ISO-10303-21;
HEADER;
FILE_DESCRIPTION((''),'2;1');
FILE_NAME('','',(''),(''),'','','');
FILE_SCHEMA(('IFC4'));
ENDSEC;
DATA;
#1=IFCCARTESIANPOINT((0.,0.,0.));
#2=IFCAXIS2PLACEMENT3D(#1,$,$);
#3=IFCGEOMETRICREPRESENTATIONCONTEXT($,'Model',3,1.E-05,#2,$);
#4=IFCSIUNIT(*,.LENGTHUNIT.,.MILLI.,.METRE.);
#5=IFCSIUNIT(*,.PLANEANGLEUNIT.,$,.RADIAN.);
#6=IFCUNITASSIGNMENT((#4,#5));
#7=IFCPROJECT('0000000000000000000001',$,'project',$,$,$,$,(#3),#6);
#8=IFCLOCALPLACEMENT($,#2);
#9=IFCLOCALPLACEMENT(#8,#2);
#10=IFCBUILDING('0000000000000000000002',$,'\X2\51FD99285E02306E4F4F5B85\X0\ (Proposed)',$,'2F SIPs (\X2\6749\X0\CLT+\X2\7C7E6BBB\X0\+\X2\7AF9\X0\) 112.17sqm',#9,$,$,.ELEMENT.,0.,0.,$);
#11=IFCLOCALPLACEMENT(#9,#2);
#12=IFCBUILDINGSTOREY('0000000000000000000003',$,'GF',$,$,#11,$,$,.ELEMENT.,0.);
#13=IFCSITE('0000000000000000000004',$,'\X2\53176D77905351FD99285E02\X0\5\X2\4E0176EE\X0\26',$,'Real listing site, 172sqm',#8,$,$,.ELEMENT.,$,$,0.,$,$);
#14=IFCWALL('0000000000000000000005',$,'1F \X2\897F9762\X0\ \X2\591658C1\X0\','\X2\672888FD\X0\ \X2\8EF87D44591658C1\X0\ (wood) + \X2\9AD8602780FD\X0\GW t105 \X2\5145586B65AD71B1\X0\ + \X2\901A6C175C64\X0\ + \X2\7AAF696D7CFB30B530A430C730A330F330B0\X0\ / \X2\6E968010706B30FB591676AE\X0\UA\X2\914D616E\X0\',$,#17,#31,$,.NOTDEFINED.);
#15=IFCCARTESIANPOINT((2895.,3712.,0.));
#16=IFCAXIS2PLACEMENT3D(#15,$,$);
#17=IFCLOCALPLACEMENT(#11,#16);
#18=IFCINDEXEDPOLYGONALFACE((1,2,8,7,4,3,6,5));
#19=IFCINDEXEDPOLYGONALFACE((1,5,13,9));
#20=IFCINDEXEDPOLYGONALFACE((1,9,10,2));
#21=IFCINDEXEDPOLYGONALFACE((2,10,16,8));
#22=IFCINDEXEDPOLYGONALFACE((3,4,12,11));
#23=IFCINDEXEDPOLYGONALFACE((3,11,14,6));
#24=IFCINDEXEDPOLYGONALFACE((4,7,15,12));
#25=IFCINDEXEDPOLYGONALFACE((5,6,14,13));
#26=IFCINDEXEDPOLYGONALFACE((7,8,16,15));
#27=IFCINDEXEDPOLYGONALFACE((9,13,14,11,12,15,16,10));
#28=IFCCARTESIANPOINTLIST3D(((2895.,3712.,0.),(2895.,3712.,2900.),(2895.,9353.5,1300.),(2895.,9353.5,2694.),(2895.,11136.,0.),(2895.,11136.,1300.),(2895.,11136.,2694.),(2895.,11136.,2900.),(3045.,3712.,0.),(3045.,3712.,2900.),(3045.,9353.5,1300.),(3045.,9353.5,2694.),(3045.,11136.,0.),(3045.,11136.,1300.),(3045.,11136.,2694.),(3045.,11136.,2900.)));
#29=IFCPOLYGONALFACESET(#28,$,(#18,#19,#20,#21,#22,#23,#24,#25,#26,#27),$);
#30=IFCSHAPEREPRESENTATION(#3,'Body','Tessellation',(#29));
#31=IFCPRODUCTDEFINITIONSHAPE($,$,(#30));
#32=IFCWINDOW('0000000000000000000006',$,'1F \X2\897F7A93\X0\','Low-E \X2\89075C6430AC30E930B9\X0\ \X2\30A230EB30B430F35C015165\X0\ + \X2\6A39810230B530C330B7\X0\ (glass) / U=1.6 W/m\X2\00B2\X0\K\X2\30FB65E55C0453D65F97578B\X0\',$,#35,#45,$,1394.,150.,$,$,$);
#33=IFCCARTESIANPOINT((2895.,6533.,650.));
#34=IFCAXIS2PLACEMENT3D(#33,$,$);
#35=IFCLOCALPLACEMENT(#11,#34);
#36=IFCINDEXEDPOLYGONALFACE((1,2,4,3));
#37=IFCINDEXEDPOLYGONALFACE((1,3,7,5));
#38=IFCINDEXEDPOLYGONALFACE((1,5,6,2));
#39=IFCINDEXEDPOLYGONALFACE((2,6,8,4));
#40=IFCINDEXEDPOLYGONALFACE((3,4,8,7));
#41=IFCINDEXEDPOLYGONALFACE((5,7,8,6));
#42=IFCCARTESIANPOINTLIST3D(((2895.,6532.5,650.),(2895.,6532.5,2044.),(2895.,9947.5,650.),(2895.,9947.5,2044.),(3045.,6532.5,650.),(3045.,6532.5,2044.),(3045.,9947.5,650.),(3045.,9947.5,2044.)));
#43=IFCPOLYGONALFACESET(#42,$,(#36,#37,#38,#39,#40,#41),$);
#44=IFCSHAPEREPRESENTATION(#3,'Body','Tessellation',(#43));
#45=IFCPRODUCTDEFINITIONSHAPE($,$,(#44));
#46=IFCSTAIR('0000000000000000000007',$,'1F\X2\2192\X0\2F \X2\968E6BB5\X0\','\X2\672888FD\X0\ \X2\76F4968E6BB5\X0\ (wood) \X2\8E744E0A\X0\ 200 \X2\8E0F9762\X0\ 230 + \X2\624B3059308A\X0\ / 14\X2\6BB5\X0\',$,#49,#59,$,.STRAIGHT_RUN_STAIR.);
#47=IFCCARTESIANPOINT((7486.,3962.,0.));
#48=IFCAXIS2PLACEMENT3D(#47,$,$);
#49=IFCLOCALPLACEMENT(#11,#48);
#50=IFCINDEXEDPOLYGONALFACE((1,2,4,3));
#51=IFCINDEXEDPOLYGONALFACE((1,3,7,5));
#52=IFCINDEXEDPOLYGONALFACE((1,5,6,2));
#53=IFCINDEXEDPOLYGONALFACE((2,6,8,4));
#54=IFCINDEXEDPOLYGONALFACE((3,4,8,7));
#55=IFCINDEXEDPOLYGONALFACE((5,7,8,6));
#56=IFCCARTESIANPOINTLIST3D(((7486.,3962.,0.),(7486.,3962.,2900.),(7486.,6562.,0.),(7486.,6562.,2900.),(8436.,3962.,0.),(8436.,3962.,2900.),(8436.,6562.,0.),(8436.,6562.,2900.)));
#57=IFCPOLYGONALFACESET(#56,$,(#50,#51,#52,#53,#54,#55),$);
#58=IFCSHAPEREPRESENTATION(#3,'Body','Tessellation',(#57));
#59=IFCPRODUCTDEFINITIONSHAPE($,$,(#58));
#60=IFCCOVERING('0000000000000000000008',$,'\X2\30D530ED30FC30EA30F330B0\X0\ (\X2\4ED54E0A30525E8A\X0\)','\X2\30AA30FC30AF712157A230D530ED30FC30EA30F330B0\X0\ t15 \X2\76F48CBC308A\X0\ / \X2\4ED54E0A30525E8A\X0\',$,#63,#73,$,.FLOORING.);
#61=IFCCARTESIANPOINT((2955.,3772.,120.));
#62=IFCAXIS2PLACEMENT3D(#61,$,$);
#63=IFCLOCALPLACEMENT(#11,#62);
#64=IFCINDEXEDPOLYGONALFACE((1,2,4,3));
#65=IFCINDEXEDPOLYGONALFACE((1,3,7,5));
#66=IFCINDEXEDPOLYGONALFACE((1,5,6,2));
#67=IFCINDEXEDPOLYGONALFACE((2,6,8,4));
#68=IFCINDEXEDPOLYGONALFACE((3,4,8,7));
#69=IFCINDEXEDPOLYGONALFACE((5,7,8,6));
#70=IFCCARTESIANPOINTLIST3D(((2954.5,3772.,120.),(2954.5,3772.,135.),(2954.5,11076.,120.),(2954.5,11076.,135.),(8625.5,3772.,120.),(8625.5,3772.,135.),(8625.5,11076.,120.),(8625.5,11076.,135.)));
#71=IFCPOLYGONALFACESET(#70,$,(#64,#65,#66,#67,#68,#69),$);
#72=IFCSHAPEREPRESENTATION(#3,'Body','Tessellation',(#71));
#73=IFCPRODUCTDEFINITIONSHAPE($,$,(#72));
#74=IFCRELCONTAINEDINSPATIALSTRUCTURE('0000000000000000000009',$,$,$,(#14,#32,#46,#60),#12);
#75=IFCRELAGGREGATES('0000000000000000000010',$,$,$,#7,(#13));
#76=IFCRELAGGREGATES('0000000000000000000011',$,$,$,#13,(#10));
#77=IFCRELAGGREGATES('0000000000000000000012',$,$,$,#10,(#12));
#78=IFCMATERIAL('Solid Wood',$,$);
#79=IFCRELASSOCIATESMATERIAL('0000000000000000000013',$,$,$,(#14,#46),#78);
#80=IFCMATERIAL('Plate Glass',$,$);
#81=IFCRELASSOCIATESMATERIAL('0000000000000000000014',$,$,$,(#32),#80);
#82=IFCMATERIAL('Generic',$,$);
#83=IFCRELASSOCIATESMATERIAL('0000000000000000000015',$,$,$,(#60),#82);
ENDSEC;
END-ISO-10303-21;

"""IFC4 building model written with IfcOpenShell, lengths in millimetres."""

from ifc_helpers import new_model, si_unit, frame, frame_2d, origin, place, context, project, spatial, rectangle, extrude, material, element, fill, save


model = new_model("IFC4")

# Units and contexts
model_context = context("Model", 3, precision=1e-05, world=origin())
ifc_project = project(units=[si_unit("LENGTHUNIT", "METRE", prefix="MILLI"), si_unit("PLANEANGLEUNIT", "RADIAN")], contexts=[model_context])

# Site, building, storey
site_placement = place(None, origin())
site = spatial("IfcSite", under=ifc_project, at=site_placement, Name="北海道函館市5丁目26", ObjectType="Real listing site, 172sqm", CompositionType="ELEMENT", RefElevation=0.0)
building_placement = place(site_placement, origin())
building = spatial("IfcBuilding", under=site, at=building_placement, Name="函館市の住宅 (Proposed)", ObjectType="2F SIPs (杉CLT+籾殻+竹) 112.17sqm", CompositionType="ELEMENT", ElevationOfRefHeight=0.0, ElevationOfTerrain=0.0)
storey_placement = place(building_placement, origin())
storey = spatial("IfcBuildingStorey", under=building, at=storey_placement, Name="GF", CompositionType="ELEMENT", Elevation=0.0)

# Shared definitions
ifc_material_1 = material(Name="Solid Wood")
ifc_material_2 = material(Name="Generic")

# Shared definitions
ifc_material_3 = material(Name="Plate Glass")

# Wall, opening, window
wall_1_placement = place(storey_placement, frame((2895.0, 3712.0, 0.0)))
wall_1 = element("IfcWall", 1, at=wall_1_placement, inside=storey, material=ifc_material_1, Name="1F 西面 外壁", Description="木製 軸組外壁 (wood) + 高性能GW t105 充填断熱 + 通気層 + 窯業系サイディング / 準耐火・外皮UA配慮", PredefinedType="NOTDEFINED", context=model_context, shape_type="SweptSolid", body=[
    extrude(rectangle(XDim=150.0, YDim=7424.0, at=frame_2d((75.0, 3712.0))), frame((2895.0, 3712.0, 0.0)), (0.0, 0.0, 1.0), 2900.0),
])
opening_1_placement = place(storey_placement, frame((2895.0, 6533.0, 650.0)))
opening_1 = element("IfcOpeningElement", 2, at=opening_1_placement, cuts=wall_1, PredefinedType="NOTDEFINED", context=model_context, shape_type="SweptSolid", body=[
    extrude(rectangle(XDim=150.0, YDim=3415.0, at=frame_2d((75.0, 1707.0))), frame((2895.0, 6533.0, 650.0)), (0.0, 0.0, 1.0), 1394.0),
])
window_1_placement = place(storey_placement, frame((2895.0, 6533.0, 650.0)))
window_1 = element("IfcWindow", 3, at=window_1_placement, inside=storey, material=ifc_material_3, Name="1F 西窓", Description="Low-E 複層ガラス アルゴン封入 + 樹脂サッシ (glass) / U=1.6 W/m²K・日射取得型", OverallHeight=1394.0, OverallWidth=150.0, context=model_context, shape_type="SweptSolid", body=[
    extrude(rectangle(XDim=150.0, YDim=3415.0, at=frame_2d((75.0, 1707.0))), frame((2895.0, 6533.0, 650.0)), (0.0, 0.0, 1.0), 1394.0),
])
fill(opening_1, window_1)

# Stair
stair_placement = place(storey_placement, frame((7486.0, 3962.0, 0.0)))
element("IfcStair", 4, at=stair_placement, inside=storey, material=ifc_material_1, Name="1F→2F 階段", Description="木製 直階段 (wood) 蹴上 200 踏面 230 + 手すり / 14段", PredefinedType="STRAIGHT_RUN_STAIR", context=model_context, shape_type="SweptSolid", body=[
    extrude(rectangle(XDim=950.0, YDim=2600.0, at=frame_2d((475.0, 1300.0))), frame((7486.0, 3962.0, 0.0)), (0.0, 0.0, 1.0), 2900.0),
])

# Covering
covering_placement = place(storey_placement, frame((2955.0, 3772.0, 120.0)))
element("IfcCovering", 5, at=covering_placement, inside=storey, material=ifc_material_2, Name="フローリング (仕上げ床)", Description="オーク無垢フローリング t15 直貼り / 仕上げ床", PredefinedType="FLOORING", context=model_context, shape_type="SweptSolid", body=[
    extrude(rectangle(XDim=5671.0, YDim=7304.0, at=frame_2d((2835.0, 3652.0))), frame((2955.0, 3772.0, 120.0)), (0.0, 0.0, 1.0), 15.0),
])

save(model, "model.ifc")
